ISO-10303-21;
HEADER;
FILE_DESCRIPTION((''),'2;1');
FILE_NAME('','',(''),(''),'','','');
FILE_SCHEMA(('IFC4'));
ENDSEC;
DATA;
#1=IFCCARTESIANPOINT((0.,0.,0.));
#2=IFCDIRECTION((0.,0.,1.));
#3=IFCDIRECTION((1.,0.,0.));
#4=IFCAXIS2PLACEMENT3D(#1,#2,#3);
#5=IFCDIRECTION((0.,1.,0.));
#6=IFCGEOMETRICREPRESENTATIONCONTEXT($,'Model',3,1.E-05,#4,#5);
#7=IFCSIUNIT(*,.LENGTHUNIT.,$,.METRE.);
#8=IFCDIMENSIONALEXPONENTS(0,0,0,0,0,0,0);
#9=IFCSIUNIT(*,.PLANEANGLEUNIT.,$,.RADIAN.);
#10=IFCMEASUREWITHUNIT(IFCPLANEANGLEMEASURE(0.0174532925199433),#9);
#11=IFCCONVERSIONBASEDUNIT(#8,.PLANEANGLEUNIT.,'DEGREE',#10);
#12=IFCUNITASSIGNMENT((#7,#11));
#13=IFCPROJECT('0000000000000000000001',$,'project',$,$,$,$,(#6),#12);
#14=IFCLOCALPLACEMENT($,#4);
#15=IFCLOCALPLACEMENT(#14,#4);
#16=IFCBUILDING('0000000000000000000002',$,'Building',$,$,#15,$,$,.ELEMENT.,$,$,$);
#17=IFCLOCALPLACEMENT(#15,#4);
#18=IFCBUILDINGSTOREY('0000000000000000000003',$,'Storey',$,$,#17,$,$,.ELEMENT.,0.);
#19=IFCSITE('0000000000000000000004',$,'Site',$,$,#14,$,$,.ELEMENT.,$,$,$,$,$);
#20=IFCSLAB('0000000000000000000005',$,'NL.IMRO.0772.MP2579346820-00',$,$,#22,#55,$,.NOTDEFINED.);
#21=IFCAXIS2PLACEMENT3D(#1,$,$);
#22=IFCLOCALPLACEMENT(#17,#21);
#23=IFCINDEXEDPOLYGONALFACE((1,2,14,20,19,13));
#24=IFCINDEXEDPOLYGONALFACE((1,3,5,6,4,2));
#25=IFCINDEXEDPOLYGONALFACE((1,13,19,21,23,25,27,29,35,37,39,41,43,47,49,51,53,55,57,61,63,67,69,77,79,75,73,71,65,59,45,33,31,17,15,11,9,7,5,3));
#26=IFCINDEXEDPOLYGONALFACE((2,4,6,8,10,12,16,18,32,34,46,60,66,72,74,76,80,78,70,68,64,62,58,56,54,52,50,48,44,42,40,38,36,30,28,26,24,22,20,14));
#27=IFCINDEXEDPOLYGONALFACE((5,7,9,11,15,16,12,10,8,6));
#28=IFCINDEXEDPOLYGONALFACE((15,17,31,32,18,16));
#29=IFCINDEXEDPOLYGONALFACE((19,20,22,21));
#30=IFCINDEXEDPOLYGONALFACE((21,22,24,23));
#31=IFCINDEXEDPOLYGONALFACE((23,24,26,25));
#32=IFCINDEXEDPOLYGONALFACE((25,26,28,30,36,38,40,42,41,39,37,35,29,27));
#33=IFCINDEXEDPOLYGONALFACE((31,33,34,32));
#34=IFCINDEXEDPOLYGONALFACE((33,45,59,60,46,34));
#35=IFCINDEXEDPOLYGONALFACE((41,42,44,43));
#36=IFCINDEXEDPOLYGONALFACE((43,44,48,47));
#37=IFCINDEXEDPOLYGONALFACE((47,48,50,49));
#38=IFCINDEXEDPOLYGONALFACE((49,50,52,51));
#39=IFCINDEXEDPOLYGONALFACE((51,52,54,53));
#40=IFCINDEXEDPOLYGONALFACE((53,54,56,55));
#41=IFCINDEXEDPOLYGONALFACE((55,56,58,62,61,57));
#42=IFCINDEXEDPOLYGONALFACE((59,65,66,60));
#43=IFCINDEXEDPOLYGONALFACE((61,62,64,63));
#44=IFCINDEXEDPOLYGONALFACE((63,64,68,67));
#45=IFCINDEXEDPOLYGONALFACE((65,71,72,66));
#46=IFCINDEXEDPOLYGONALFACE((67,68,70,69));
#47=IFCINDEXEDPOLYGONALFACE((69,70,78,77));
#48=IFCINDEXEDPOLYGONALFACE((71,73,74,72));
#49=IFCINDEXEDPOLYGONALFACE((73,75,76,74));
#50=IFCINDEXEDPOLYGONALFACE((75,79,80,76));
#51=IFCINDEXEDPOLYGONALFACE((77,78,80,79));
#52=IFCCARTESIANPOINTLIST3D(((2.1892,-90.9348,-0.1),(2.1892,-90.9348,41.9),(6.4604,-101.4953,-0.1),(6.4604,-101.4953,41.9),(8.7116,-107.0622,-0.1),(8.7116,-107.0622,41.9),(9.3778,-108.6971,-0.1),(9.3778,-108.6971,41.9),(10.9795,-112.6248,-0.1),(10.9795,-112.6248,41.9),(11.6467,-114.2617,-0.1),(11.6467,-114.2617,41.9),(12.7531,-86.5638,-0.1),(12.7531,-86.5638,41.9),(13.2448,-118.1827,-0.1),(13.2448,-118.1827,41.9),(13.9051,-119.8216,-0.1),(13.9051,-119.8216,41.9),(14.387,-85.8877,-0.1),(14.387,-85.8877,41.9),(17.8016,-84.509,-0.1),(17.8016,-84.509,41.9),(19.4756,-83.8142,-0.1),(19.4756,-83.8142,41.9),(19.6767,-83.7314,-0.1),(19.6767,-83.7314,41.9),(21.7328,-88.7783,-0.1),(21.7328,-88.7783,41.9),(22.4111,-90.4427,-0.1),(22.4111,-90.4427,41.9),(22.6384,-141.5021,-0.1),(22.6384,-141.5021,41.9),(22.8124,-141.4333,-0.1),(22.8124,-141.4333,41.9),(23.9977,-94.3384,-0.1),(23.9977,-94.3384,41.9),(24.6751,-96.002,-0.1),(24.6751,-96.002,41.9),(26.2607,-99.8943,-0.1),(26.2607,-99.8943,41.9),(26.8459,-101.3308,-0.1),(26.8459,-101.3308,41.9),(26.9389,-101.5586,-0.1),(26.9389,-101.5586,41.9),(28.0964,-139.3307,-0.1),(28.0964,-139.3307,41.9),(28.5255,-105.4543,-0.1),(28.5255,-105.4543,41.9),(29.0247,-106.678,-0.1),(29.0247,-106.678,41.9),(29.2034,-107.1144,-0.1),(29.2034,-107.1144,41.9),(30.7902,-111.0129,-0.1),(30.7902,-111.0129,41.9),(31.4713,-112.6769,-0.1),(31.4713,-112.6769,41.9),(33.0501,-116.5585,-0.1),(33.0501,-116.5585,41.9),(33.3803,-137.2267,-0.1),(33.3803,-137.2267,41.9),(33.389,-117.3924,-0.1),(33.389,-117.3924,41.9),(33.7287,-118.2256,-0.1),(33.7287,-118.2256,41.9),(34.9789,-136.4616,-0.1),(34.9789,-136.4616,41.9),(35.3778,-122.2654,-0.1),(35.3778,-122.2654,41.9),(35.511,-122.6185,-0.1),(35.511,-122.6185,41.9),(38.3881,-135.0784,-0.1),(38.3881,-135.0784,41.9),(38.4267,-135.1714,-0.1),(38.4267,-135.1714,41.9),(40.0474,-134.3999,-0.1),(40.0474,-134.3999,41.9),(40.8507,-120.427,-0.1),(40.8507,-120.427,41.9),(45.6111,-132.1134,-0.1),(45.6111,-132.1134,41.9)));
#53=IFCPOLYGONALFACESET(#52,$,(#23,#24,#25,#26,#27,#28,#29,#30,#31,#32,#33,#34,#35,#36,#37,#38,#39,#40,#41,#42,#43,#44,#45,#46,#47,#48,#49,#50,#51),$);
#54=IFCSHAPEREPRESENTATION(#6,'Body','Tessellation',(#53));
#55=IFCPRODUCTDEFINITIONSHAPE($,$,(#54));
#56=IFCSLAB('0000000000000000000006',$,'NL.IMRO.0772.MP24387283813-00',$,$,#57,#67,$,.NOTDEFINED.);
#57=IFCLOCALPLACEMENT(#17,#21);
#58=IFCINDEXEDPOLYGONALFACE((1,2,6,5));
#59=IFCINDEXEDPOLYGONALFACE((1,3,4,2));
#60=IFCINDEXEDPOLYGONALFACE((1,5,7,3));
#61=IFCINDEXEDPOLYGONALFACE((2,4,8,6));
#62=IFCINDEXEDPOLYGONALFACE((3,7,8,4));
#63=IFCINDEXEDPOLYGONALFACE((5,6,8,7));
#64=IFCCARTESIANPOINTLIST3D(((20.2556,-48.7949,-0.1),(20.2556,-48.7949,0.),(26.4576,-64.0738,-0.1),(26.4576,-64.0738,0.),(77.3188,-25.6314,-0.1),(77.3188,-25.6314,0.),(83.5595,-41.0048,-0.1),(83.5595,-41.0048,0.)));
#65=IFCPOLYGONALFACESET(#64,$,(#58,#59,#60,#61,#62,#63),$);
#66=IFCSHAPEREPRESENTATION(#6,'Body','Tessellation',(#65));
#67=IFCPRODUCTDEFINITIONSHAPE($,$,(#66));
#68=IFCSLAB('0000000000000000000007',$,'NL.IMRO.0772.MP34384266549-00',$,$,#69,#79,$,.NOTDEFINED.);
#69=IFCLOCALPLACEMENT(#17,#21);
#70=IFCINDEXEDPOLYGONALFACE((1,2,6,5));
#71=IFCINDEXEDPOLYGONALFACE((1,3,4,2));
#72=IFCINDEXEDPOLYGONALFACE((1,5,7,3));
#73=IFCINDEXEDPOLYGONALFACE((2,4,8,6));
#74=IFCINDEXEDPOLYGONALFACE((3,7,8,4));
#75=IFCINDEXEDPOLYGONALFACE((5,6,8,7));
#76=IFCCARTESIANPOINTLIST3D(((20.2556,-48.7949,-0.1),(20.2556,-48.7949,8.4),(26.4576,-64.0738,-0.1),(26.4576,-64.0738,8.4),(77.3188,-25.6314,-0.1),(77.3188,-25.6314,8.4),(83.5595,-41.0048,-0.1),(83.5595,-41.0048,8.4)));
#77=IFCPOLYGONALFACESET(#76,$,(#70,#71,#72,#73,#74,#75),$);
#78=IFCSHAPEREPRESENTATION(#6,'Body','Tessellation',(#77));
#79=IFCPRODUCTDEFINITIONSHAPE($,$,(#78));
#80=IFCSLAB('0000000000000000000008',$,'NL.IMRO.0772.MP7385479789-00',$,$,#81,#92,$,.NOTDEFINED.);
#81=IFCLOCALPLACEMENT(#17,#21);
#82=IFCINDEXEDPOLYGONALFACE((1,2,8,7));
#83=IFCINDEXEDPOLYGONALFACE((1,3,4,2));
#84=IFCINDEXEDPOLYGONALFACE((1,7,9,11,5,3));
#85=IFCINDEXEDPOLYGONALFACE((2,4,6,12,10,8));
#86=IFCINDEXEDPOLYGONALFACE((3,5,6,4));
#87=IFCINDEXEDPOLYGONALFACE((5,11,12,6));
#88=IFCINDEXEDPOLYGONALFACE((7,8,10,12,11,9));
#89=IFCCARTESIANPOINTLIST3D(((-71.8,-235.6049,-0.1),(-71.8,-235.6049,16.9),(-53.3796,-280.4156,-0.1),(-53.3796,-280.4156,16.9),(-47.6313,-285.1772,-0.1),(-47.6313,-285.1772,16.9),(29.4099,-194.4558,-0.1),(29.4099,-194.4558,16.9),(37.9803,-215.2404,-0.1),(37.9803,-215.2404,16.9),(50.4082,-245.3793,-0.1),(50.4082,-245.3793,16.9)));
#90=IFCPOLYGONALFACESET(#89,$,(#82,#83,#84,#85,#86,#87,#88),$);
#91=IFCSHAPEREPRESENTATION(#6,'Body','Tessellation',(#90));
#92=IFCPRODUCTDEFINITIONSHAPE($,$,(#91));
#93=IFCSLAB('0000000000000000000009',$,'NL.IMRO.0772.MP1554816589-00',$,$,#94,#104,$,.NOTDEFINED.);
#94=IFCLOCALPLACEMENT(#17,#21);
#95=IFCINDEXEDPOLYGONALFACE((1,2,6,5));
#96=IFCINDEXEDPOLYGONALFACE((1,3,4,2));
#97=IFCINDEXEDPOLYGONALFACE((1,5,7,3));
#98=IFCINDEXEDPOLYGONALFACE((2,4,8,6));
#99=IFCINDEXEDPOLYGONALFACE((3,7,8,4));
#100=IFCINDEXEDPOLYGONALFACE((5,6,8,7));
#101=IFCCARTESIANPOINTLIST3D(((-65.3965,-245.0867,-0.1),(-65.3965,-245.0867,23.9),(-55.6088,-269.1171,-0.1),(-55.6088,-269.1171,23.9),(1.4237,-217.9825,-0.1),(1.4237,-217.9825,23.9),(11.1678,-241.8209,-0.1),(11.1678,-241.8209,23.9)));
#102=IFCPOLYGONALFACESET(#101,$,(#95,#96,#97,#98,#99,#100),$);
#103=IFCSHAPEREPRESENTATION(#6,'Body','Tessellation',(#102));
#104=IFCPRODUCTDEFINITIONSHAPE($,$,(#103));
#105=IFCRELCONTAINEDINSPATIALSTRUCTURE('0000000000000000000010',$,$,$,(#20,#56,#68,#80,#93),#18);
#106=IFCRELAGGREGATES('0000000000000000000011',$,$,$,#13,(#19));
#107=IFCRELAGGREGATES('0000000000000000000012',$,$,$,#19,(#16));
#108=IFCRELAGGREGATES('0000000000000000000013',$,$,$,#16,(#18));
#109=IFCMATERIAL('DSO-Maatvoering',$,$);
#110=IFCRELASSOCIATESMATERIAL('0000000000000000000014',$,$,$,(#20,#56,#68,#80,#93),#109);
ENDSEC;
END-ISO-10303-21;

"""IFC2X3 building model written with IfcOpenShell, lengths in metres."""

from ifc_helpers import new_model, entity, si_unit, converted_unit, direction, frame, origin_with_axes, place, context, project, spatial, polyline, outline, extrude, material, element, save


model = new_model("IFC2X3")

# Units and contexts
model_context = context("Model", 3, precision=1e-05, world=origin_with_axes(), true_north=direction((0.0, 1.0, 0.0)))
ifc_project = project(units=[si_unit("LENGTHUNIT", "METRE"), converted_unit("PLANEANGLEUNIT", "DEGREE", entity("IfcPlaneAngleMeasure", 0.0174532925199433), si_unit("PLANEANGLEUNIT", "RADIAN"), dimensions=[0, 0, 0, 0, 0, 0, 0])], contexts=[model_context])

# Site, building, storey
site_placement = place(None, origin_with_axes())
site = spatial("IfcSite", under=ifc_project, at=site_placement, Name="Site", CompositionType="ELEMENT")
building_placement = place(site_placement, origin_with_axes())
building = spatial("IfcBuilding", under=site, at=building_placement, Name="Building", CompositionType="ELEMENT")
storey_placement = place(building_placement, origin_with_axes())
storey = spatial("IfcBuildingStorey", under=building, at=storey_placement, Name="Storey", CompositionType="ELEMENT", Elevation=0.0)

# Slabs
ifc_material = material(Name="DSO-Maatvoering")
for number, where, z_axis, x_axis, name in (
    (1, (0.0, 0.0, -0.1), (0.0, 0.0, 1.0), (1.0, 0.0, 0.0), "NL.IMRO.0772.MP2579346820-00"),
):
    element("IfcSlab", number, at=place(storey_placement, frame(where, z_axis=z_axis, x_axis=x_axis)), inside=storey, material=ifc_material, Name=name, PredefinedType="NOTDEFINED", context=model_context, shape_type="SweptSolid", body=[
        extrude(outline(polyline([(10.9795, -112.6248), (9.3778, -108.6971), (8.7116, -107.0622), (6.4604, -101.4953), (2.1892, -90.9348), (12.7531, -86.5638), (14.387, -85.8877), (17.8016, -84.509), (19.4756, -83.8142), (19.6767, -83.7314), (21.7328, -88.7783), (22.4111, -90.4427), (23.9977, -94.3384), (24.6751, -96.002), (26.2607, -99.8943), (26.8459, -101.3308), (26.9389, -101.5586), (28.5255, -105.4543), (29.0247, -106.678), (29.2034, -107.1144), (30.7902, -111.0129), (31.4713, -112.6769), (33.0501, -116.5585), (33.389, -117.3924), (33.7287, -118.2256), (35.3778, -122.2654), (35.511, -122.6185), (40.8507, -120.427), (45.6111, -132.1134), (40.0474, -134.3999), (38.4267, -135.1714), (38.3881, -135.0784), (34.9789, -136.4616), (33.3803, -137.2267), (28.0964, -139.3307), (22.8124, -141.4333), (22.6384, -141.5021), (13.9051, -119.8216), (13.2448, -118.1827), (11.6467, -114.2617), (10.9795, -112.6248)])), origin_with_axes(), (0.0, 0.0, 1.0), 42.0),
    ])
slab_1_placement = place(storey_placement, frame((0.0, 0.0, -0.1), z_axis=(0.0, 0.0, 1.0), x_axis=(1.0, 0.0, 0.0)))
element("IfcSlab", 2, at=slab_1_placement, inside=storey, material=ifc_material, Name="NL.IMRO.0772.MP24387283813-00", PredefinedType="NOTDEFINED", context=model_context, shape_type="SweptSolid", body=[
    extrude(outline(polyline([(77.3188, -25.6314), (83.5595, -41.0048), (26.4576, -64.0738), (20.2556, -48.7949), (77.3188, -25.6314)])), origin_with_axes(), (0.0, 0.0, 1.0), 0.1),
])
slab_2_placement = place(storey_placement, frame((0.0, 0.0, -0.1), z_axis=(0.0, 0.0, 1.0), x_axis=(1.0, 0.0, 0.0)))
element("IfcSlab", 3, at=slab_2_placement, inside=storey, material=ifc_material, Name="NL.IMRO.0772.MP34384266549-00", PredefinedType="NOTDEFINED", context=model_context, shape_type="SweptSolid", body=[
    extrude(outline(polyline([(77.3188, -25.6314), (83.5595, -41.0048), (26.4576, -64.0738), (20.2556, -48.7949), (77.3188, -25.6314)])), origin_with_axes(), (0.0, 0.0, 1.0), 8.5),
])
slab_3_placement = place(storey_placement, frame((0.0, 0.0, -0.1), z_axis=(0.0, 0.0, 1.0), x_axis=(1.0, 0.0, 0.0)))
element("IfcSlab", 4, at=slab_3_placement, inside=storey, material=ifc_material, Name="NL.IMRO.0772.MP7385479789-00", PredefinedType="NOTDEFINED", context=model_context, shape_type="SweptSolid", body=[
    extrude(outline(polyline([(-71.8, -235.6049), (29.4099, -194.4558), (37.9803, -215.2404), (50.4082, -245.3793), (-47.6313, -285.1772), (-53.3796, -280.4156), (-71.8, -235.6049)])), origin_with_axes(), (0.0, 0.0, 1.0), 17.0),
])
for number, where, z_axis, x_axis, name in (
    (5, (0.0, 0.0, -0.1), (0.0, 0.0, 1.0), (1.0, 0.0, 0.0), "NL.IMRO.0772.MP1554816589-00"),
):
    element("IfcSlab", number, at=place(storey_placement, frame(where, z_axis=z_axis, x_axis=x_axis)), inside=storey, material=ifc_material, Name=name, PredefinedType="NOTDEFINED", context=model_context, shape_type="SweptSolid", body=[
        extrude(outline(polyline([(1.4237, -217.9825), (11.1678, -241.8209), (-55.6088, -269.1171), (-65.3965, -245.0867), (1.4237, -217.9825)])), origin_with_axes(), (0.0, 0.0, 1.0), 24.0),
    ])

save(model, "model.ifc")
